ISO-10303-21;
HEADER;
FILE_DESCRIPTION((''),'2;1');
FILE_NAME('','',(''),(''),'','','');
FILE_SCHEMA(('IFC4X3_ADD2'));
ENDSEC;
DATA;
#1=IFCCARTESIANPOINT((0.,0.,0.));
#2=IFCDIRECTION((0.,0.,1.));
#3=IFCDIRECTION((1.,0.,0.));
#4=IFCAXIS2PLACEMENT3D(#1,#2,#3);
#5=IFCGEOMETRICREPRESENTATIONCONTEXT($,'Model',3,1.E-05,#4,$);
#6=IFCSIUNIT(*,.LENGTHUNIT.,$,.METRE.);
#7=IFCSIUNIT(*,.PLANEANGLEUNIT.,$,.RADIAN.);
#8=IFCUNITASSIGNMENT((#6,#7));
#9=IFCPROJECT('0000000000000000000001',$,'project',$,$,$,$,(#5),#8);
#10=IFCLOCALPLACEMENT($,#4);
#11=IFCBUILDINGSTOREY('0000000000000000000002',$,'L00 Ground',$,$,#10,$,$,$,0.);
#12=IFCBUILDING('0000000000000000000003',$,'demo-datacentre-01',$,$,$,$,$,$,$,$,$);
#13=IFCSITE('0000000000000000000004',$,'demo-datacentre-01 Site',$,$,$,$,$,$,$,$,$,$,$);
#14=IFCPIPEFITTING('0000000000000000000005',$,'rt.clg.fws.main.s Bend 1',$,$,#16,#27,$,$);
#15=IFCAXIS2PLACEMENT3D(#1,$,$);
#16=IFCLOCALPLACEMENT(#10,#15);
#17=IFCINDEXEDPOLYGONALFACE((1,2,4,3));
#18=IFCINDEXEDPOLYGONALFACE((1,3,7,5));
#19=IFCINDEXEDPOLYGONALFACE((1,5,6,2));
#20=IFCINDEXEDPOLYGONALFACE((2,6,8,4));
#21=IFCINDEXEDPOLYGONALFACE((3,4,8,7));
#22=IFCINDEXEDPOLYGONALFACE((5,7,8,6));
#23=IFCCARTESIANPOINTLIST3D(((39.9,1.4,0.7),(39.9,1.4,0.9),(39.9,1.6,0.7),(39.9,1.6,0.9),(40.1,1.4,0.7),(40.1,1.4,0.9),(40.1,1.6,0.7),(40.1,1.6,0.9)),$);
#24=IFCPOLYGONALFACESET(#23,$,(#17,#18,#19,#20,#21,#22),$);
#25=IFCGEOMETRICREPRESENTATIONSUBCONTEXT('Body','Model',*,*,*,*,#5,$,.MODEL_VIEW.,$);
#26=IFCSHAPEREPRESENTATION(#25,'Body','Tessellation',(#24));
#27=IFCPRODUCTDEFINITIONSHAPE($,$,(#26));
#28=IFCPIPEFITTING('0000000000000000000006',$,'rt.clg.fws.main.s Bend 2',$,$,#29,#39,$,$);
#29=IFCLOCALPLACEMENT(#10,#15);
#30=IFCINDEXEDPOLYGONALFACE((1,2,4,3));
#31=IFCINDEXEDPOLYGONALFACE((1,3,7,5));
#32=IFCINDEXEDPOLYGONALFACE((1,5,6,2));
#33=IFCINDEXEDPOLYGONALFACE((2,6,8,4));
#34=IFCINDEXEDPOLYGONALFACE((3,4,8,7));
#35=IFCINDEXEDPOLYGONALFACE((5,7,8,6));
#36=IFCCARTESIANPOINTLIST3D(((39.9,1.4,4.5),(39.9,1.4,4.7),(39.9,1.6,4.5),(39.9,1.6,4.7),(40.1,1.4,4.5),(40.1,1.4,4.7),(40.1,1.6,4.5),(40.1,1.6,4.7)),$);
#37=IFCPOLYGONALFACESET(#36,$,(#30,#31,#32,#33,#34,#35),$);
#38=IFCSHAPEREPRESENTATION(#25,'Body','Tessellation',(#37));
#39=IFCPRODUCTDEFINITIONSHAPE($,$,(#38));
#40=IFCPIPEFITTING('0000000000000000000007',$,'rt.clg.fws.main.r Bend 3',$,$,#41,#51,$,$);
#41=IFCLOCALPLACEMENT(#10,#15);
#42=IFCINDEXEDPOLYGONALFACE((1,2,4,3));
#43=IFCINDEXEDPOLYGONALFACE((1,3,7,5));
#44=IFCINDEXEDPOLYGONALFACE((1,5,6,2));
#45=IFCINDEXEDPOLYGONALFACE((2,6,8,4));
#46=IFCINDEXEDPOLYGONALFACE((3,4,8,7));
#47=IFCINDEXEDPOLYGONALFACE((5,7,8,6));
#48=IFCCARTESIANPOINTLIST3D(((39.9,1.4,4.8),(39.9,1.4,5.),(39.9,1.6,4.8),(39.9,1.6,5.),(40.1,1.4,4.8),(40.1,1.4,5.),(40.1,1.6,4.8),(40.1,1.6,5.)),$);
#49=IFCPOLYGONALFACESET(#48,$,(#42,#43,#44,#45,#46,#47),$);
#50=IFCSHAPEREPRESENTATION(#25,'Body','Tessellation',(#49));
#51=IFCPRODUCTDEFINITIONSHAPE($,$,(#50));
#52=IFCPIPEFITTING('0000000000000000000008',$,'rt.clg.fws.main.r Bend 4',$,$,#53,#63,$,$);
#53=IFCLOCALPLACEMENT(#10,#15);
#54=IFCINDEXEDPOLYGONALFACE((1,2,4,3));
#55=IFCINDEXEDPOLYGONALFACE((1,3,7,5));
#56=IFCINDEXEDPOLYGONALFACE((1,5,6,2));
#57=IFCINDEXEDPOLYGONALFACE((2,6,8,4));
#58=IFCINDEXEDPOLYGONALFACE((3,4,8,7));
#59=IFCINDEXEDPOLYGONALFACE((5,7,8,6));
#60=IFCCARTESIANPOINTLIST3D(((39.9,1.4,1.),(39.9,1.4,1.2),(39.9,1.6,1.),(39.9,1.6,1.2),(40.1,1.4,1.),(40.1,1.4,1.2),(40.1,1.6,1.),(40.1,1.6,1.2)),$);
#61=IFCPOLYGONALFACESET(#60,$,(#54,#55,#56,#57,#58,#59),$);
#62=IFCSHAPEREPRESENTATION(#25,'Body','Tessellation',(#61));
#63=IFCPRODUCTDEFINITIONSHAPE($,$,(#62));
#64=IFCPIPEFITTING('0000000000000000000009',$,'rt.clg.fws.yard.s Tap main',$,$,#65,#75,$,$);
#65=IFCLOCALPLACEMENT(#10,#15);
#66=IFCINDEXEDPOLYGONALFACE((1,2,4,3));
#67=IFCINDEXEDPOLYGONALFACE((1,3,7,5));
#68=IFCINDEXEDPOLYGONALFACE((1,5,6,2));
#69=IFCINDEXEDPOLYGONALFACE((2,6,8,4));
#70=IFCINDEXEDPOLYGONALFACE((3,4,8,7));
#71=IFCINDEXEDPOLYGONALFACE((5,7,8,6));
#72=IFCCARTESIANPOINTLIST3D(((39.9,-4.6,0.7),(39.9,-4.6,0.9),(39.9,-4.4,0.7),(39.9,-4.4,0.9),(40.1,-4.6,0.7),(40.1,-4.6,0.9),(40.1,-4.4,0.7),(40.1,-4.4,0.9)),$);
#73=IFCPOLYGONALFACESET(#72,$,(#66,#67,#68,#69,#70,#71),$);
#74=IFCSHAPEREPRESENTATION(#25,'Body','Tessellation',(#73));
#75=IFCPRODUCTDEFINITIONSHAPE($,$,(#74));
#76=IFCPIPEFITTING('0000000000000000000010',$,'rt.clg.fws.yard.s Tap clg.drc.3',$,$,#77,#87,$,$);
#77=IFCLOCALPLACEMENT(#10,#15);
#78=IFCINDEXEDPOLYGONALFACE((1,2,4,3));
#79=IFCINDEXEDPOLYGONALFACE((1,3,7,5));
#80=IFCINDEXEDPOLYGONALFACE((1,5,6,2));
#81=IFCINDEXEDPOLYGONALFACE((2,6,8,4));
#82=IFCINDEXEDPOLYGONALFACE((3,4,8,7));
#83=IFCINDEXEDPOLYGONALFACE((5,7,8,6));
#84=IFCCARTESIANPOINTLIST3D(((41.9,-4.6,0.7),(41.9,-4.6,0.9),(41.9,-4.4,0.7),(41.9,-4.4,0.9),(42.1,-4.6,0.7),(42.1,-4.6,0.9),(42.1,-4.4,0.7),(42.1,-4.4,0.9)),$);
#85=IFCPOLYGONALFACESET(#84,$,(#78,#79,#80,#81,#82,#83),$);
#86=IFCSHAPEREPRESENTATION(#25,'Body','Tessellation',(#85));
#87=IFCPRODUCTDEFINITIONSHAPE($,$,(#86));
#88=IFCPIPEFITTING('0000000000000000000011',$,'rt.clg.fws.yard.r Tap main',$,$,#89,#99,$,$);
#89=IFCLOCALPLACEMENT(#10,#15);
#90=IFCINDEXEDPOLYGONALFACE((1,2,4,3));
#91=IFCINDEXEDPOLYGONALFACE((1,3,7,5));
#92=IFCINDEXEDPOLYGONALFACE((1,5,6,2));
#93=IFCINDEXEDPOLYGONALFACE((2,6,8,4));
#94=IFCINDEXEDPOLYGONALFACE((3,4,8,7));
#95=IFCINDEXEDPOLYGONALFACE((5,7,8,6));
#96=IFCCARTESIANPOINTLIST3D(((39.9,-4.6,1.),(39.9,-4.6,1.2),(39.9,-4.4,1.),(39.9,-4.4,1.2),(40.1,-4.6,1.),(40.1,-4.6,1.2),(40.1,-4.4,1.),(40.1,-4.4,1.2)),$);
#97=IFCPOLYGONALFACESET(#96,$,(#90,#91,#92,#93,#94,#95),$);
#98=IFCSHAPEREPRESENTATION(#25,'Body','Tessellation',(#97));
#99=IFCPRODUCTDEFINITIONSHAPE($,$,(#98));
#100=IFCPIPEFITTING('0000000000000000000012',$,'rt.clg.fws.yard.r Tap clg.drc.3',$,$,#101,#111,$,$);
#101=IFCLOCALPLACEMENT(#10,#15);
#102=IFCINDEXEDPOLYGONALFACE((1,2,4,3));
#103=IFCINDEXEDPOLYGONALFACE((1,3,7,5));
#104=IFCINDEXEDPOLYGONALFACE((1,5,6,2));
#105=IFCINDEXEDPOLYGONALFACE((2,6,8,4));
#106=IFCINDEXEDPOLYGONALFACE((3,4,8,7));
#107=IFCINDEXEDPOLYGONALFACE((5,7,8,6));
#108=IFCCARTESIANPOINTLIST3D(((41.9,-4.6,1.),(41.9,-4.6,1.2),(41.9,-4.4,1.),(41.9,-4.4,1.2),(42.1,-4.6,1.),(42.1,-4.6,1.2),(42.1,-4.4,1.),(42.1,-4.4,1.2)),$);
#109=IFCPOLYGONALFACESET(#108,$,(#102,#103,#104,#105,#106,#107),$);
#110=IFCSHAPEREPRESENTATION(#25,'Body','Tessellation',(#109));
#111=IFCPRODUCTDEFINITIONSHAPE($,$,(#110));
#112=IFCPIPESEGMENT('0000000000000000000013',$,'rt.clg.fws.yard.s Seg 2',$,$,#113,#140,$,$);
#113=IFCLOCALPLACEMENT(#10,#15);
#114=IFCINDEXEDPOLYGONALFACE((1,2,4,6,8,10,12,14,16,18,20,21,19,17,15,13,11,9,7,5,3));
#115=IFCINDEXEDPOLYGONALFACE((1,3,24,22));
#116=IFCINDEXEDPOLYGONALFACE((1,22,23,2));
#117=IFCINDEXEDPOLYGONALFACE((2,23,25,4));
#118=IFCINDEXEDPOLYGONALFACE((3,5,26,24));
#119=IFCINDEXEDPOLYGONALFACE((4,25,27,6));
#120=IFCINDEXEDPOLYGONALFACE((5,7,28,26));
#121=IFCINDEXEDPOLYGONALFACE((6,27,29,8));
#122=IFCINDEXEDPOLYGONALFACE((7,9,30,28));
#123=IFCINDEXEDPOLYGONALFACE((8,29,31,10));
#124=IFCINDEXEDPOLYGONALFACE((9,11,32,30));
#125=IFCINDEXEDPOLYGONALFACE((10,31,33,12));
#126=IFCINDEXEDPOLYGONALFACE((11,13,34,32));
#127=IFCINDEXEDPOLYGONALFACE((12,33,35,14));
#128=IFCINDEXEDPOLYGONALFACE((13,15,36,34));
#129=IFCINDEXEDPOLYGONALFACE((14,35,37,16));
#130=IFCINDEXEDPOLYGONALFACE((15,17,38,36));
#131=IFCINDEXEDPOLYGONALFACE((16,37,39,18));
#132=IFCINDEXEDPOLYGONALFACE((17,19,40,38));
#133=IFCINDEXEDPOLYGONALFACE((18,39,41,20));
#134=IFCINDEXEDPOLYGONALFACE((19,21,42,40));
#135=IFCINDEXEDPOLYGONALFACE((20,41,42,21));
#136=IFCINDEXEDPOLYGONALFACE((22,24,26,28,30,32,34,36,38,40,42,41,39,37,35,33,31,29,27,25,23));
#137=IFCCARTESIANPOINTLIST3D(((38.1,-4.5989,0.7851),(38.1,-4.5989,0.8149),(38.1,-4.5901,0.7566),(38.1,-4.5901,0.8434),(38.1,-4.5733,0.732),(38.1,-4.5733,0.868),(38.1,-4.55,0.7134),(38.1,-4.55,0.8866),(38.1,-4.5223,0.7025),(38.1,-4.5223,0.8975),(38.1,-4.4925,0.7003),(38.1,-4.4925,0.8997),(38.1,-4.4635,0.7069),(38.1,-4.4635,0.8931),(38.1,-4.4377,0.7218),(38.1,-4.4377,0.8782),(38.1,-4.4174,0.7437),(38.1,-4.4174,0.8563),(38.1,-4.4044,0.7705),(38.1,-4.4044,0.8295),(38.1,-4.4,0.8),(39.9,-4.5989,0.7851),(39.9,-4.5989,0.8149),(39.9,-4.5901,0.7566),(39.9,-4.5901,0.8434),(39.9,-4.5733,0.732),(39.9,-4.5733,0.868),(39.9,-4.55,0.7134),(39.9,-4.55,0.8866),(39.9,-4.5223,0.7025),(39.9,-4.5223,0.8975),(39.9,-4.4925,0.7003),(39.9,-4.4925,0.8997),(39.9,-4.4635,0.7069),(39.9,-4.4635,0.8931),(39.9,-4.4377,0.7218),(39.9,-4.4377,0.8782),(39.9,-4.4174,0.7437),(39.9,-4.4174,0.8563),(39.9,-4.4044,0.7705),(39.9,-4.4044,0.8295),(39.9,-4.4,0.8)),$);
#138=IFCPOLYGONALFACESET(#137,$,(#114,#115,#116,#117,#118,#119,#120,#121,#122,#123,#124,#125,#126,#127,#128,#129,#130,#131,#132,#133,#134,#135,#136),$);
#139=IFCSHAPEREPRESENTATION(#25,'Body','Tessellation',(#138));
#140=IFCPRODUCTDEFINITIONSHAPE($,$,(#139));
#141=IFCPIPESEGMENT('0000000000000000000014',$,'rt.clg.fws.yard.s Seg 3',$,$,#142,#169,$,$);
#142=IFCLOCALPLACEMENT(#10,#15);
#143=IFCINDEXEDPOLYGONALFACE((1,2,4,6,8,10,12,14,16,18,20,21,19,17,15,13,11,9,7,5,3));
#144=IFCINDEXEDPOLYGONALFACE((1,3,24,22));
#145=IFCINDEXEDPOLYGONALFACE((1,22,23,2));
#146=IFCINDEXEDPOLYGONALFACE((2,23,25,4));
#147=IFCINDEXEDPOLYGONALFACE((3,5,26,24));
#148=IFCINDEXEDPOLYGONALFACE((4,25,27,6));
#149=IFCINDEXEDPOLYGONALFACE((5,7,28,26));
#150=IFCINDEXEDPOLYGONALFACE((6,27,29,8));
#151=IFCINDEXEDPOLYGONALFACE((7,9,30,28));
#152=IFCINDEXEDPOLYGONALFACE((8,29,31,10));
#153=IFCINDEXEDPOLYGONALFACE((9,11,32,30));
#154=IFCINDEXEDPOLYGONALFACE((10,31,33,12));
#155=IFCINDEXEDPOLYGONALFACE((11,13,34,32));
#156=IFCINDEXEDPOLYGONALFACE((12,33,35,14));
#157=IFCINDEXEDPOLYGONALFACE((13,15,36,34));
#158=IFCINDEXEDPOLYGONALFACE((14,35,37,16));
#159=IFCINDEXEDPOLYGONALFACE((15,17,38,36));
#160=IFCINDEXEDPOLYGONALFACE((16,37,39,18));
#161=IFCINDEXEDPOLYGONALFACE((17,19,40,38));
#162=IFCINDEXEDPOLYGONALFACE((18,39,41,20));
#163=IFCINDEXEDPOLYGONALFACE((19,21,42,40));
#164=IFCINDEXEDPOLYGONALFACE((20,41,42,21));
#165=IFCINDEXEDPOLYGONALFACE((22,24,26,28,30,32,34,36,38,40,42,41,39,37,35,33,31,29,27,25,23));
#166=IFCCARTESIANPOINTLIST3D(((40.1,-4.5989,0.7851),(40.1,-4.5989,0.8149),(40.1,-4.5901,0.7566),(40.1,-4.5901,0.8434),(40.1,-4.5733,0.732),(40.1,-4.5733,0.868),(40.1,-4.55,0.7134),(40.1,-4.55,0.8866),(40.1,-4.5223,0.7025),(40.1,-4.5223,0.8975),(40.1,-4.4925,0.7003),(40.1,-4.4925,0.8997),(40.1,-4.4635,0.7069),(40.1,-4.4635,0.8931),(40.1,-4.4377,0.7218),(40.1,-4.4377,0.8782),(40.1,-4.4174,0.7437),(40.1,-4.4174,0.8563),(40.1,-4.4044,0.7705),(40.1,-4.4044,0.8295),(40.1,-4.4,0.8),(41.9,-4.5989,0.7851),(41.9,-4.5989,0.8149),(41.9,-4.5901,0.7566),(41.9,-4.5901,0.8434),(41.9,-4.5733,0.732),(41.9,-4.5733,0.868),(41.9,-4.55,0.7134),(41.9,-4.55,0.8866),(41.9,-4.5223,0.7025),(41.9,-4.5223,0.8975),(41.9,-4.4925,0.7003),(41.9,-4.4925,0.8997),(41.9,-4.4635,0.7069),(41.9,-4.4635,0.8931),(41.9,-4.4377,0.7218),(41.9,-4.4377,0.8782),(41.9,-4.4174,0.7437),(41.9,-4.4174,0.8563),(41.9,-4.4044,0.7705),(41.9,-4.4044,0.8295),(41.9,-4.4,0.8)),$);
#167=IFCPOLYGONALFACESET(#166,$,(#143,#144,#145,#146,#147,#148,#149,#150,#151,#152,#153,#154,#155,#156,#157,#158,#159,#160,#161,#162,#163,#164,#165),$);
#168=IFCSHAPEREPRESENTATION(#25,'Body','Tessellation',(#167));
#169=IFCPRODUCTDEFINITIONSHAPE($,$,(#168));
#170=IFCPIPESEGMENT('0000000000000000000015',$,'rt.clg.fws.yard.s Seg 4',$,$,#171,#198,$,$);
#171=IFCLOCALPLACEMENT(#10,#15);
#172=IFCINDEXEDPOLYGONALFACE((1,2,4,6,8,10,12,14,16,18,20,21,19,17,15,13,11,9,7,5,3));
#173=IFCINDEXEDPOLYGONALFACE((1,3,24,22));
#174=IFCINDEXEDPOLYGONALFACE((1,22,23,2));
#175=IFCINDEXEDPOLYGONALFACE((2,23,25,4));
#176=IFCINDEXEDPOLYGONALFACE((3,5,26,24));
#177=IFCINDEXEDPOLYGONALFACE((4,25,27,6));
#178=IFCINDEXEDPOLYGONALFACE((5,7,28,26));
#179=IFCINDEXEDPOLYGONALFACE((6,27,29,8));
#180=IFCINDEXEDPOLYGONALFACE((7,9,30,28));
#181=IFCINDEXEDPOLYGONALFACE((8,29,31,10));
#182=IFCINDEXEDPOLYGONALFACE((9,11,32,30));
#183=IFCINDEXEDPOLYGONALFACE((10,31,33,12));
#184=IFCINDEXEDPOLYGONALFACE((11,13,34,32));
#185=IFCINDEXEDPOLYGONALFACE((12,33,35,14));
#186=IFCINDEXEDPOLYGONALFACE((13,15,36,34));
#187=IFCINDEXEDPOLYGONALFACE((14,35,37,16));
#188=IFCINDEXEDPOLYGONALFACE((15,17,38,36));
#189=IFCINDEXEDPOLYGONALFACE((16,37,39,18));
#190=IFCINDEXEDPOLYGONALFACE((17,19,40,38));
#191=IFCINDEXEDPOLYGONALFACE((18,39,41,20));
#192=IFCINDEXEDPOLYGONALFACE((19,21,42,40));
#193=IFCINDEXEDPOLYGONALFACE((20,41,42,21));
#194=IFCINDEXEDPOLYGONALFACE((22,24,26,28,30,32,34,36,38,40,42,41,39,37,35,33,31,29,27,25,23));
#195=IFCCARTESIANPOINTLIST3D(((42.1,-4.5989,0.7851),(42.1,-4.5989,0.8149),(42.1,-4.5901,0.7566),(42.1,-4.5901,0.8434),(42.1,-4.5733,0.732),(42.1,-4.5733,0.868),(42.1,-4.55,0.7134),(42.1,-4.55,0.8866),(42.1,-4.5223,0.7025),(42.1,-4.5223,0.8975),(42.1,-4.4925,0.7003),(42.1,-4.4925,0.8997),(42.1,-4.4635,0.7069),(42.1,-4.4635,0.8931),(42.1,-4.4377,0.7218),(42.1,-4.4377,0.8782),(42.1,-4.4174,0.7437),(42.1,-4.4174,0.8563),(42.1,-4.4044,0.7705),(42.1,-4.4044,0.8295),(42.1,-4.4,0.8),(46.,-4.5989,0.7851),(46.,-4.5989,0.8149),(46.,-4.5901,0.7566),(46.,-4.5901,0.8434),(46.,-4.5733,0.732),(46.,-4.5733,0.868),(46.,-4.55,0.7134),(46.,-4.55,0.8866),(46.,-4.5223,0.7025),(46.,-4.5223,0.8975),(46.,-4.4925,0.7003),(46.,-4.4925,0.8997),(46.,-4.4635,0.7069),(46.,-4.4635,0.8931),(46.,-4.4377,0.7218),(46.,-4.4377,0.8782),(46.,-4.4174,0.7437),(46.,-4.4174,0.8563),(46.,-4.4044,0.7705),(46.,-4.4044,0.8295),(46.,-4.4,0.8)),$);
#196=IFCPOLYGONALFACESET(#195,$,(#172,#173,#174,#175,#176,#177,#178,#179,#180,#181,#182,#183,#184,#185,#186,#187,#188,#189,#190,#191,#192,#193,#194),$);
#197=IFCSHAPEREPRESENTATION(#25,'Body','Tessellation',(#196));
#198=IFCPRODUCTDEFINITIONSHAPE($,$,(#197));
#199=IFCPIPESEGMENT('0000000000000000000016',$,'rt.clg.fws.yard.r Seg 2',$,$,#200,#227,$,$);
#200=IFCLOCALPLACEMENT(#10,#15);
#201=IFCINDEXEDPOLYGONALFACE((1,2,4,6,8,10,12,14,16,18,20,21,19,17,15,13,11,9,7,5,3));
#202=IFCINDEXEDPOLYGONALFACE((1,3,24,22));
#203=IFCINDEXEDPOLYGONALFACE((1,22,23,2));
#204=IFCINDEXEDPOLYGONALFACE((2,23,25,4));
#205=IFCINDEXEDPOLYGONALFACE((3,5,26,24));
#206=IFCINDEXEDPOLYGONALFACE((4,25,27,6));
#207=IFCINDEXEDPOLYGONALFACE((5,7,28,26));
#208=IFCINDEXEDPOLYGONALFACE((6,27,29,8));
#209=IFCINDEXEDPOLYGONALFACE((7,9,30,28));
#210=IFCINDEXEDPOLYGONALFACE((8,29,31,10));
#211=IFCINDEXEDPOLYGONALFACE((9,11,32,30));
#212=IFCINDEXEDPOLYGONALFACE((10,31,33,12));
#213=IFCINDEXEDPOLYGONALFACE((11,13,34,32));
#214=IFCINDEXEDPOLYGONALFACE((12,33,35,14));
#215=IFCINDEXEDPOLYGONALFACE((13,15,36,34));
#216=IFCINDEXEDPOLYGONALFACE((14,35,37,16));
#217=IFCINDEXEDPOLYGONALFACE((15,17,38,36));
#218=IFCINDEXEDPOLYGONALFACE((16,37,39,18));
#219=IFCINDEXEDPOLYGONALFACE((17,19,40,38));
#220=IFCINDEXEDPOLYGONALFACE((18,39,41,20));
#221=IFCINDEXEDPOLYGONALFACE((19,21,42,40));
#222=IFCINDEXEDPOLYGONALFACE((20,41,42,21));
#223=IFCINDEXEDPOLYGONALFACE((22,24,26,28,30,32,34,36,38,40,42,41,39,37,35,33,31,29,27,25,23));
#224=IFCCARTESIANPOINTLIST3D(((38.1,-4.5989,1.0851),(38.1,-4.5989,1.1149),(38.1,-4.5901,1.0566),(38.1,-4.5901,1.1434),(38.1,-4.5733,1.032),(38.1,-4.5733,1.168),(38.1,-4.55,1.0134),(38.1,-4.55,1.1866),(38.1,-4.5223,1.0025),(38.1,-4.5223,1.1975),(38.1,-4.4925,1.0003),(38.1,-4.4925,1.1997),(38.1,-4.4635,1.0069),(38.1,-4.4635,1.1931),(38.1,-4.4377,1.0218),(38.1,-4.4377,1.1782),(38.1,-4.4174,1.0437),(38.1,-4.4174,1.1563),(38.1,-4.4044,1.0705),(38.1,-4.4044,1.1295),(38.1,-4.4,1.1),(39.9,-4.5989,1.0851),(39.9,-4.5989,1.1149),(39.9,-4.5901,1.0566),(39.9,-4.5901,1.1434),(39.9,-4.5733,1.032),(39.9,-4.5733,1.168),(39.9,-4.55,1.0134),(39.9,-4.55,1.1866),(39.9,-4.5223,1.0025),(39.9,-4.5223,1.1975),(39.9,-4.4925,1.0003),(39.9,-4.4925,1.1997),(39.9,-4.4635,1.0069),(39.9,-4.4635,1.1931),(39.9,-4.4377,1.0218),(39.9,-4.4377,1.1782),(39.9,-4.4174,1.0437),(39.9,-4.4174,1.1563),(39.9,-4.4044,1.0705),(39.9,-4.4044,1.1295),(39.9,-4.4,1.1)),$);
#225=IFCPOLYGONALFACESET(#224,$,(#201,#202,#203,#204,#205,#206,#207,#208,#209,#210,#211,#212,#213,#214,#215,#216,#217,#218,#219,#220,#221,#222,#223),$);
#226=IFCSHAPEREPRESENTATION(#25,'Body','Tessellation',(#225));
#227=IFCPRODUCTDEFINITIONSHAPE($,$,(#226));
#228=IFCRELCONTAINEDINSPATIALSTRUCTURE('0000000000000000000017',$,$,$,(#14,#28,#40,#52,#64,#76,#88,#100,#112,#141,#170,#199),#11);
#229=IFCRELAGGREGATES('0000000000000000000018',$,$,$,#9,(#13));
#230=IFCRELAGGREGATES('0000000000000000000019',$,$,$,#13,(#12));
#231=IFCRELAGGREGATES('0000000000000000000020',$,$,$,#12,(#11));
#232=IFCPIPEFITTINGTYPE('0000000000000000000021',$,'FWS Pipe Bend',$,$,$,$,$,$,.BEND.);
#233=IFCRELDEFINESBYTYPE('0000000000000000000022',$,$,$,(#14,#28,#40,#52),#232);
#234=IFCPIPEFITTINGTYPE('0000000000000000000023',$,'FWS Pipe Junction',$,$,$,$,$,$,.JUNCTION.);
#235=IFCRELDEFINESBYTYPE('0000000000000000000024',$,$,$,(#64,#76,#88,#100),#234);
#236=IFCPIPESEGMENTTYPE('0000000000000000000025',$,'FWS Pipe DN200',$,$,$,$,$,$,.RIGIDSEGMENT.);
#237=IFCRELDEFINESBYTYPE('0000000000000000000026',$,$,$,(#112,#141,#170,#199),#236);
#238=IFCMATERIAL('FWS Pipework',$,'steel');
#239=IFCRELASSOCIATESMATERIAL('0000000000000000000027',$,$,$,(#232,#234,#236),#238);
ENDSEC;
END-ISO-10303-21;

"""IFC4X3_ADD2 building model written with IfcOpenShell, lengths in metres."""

from ifc_helpers import new_model, si_unit, frame, origin_with_axes, place, context, subcontext, project, spatial, rectangle, circle, extrude, material, type_object, element, save


model = new_model("IFC4X3_ADD2")

# Units and contexts
model_context = context("Model", 3, precision=1e-05, world=origin_with_axes())
body_context = subcontext(model_context, "Body", "Model", "MODEL_VIEW")
ifc_project = project(units=[si_unit("LENGTHUNIT", "METRE"), si_unit("PLANEANGLEUNIT", "RADIAN")], contexts=[model_context])

# Site, building, storey
site = spatial("IfcSite", under=ifc_project, Name="demo-datacentre-01 Site")
building = spatial("IfcBuilding", under=site, Name="demo-datacentre-01")
storey_placement = place(None, origin_with_axes())
storey = spatial("IfcBuildingStorey", under=building, at=storey_placement, Name="L00 Ground", Elevation=0.0)

# Pipe fittings
ifc_material = material(Name="FWS Pipework", Category="steel")
pipe_fitting_type_1 = type_object("IfcPipeFittingType", Name="FWS Pipe Bend", PredefinedType="BEND", material=ifc_material)
for number, where, z_axis, x_axis, name in (
    (1, (40.0, 1.5, 0.7), (0.0, 0.0, 1.0), (1.0, 0.0, 0.0), "rt.clg.fws.main.s Bend 1"),
    (2, (40.0, 1.5, 4.5), (0.0, 0.0, 1.0), (1.0, 0.0, 0.0), "rt.clg.fws.main.s Bend 2"),
    (3, (40.0, 1.5, 4.8), (0.0, 0.0, 1.0), (1.0, 0.0, 0.0), "rt.clg.fws.main.r Bend 3"),
    (4, (40.0, 1.5, 1.0), (0.0, 0.0, 1.0), (1.0, 0.0, 0.0), "rt.clg.fws.main.r Bend 4"),
):
    element("IfcPipeFitting", number, at=place(storey_placement, frame(where, z_axis=z_axis, x_axis=x_axis)), inside=storey, type_object=pipe_fitting_type_1, Name=name, context=body_context, shape_type="SweptSolid", body=[
        extrude(rectangle(XDim=0.2, YDim=0.2), origin_with_axes(), (0.0, 0.0, 1.0), 0.2),
    ])
pipe_fitting_type_2 = type_object("IfcPipeFittingType", Name="FWS Pipe Junction", PredefinedType="JUNCTION", material=ifc_material)
for number, where, z_axis, x_axis, name in (
    (5, (40.0, -4.5, 0.7), (0.0, 0.0, 1.0), (1.0, 0.0, 0.0), "rt.clg.fws.yard.s Tap main"),
    (6, (42.0, -4.5, 0.7), (0.0, 0.0, 1.0), (1.0, 0.0, 0.0), "rt.clg.fws.yard.s Tap clg.drc.3"),
    (7, (40.0, -4.5, 1.0), (0.0, 0.0, 1.0), (1.0, 0.0, 0.0), "rt.clg.fws.yard.r Tap main"),
    (8, (42.0, -4.5, 1.0), (0.0, 0.0, 1.0), (1.0, 0.0, 0.0), "rt.clg.fws.yard.r Tap clg.drc.3"),
):
    element("IfcPipeFitting", number, at=place(storey_placement, frame(where, z_axis=z_axis, x_axis=x_axis)), inside=storey, type_object=pipe_fitting_type_2, Name=name, context=body_context, shape_type="SweptSolid", body=[
        extrude(rectangle(XDim=0.2, YDim=0.2), origin_with_axes(), (0.0, 0.0, 1.0), 0.2),
    ])

# Pipe segments
pipe_segment_type_1 = type_object("IfcPipeSegmentType", Name="FWS Pipe DN200", PredefinedType="RIGIDSEGMENT", material=ifc_material)
for number, where, z_axis, x_axis, name in (
    (9, (38.1, -4.5, 0.8), (1.0, 0.0, 0.0), (0.0, 1.0, 0.0), "rt.clg.fws.yard.s Seg 2"),
    (10, (40.1, -4.5, 0.8), (1.0, 0.0, 0.0), (0.0, 1.0, 0.0), "rt.clg.fws.yard.s Seg 3"),
):
    element("IfcPipeSegment", number, at=place(storey_placement, frame(where, z_axis=z_axis, x_axis=x_axis)), inside=storey, type_object=pipe_segment_type_1, Name=name, context=body_context, shape_type="SweptSolid", body=[
        extrude(circle(Radius=0.1), origin_with_axes(), (0.0, 0.0, 1.0), 1.8),
    ])
pipe_segment_1_placement = place(storey_placement, frame((42.1, -4.5, 0.8), z_axis=(1.0, 0.0, 0.0), x_axis=(0.0, 1.0, 0.0)))
element("IfcPipeSegment", 11, at=pipe_segment_1_placement, inside=storey, type_object=pipe_segment_type_1, Name="rt.clg.fws.yard.s Seg 4", context=body_context, shape_type="SweptSolid", body=[
    extrude(circle(Radius=0.1), origin_with_axes(), (0.0, 0.0, 1.0), 3.9),
])
for number, where, z_axis, x_axis, name in (
    (12, (38.1, -4.5, 1.1), (1.0, 0.0, 0.0), (0.0, 1.0, 0.0), "rt.clg.fws.yard.r Seg 2"),
):
    element("IfcPipeSegment", number, at=place(storey_placement, frame(where, z_axis=z_axis, x_axis=x_axis)), inside=storey, type_object=pipe_segment_type_1, Name=name, context=body_context, shape_type="SweptSolid", body=[
        extrude(circle(Radius=0.1), origin_with_axes(), (0.0, 0.0, 1.0), 1.8),
    ])

save(model, "model.ifc")
